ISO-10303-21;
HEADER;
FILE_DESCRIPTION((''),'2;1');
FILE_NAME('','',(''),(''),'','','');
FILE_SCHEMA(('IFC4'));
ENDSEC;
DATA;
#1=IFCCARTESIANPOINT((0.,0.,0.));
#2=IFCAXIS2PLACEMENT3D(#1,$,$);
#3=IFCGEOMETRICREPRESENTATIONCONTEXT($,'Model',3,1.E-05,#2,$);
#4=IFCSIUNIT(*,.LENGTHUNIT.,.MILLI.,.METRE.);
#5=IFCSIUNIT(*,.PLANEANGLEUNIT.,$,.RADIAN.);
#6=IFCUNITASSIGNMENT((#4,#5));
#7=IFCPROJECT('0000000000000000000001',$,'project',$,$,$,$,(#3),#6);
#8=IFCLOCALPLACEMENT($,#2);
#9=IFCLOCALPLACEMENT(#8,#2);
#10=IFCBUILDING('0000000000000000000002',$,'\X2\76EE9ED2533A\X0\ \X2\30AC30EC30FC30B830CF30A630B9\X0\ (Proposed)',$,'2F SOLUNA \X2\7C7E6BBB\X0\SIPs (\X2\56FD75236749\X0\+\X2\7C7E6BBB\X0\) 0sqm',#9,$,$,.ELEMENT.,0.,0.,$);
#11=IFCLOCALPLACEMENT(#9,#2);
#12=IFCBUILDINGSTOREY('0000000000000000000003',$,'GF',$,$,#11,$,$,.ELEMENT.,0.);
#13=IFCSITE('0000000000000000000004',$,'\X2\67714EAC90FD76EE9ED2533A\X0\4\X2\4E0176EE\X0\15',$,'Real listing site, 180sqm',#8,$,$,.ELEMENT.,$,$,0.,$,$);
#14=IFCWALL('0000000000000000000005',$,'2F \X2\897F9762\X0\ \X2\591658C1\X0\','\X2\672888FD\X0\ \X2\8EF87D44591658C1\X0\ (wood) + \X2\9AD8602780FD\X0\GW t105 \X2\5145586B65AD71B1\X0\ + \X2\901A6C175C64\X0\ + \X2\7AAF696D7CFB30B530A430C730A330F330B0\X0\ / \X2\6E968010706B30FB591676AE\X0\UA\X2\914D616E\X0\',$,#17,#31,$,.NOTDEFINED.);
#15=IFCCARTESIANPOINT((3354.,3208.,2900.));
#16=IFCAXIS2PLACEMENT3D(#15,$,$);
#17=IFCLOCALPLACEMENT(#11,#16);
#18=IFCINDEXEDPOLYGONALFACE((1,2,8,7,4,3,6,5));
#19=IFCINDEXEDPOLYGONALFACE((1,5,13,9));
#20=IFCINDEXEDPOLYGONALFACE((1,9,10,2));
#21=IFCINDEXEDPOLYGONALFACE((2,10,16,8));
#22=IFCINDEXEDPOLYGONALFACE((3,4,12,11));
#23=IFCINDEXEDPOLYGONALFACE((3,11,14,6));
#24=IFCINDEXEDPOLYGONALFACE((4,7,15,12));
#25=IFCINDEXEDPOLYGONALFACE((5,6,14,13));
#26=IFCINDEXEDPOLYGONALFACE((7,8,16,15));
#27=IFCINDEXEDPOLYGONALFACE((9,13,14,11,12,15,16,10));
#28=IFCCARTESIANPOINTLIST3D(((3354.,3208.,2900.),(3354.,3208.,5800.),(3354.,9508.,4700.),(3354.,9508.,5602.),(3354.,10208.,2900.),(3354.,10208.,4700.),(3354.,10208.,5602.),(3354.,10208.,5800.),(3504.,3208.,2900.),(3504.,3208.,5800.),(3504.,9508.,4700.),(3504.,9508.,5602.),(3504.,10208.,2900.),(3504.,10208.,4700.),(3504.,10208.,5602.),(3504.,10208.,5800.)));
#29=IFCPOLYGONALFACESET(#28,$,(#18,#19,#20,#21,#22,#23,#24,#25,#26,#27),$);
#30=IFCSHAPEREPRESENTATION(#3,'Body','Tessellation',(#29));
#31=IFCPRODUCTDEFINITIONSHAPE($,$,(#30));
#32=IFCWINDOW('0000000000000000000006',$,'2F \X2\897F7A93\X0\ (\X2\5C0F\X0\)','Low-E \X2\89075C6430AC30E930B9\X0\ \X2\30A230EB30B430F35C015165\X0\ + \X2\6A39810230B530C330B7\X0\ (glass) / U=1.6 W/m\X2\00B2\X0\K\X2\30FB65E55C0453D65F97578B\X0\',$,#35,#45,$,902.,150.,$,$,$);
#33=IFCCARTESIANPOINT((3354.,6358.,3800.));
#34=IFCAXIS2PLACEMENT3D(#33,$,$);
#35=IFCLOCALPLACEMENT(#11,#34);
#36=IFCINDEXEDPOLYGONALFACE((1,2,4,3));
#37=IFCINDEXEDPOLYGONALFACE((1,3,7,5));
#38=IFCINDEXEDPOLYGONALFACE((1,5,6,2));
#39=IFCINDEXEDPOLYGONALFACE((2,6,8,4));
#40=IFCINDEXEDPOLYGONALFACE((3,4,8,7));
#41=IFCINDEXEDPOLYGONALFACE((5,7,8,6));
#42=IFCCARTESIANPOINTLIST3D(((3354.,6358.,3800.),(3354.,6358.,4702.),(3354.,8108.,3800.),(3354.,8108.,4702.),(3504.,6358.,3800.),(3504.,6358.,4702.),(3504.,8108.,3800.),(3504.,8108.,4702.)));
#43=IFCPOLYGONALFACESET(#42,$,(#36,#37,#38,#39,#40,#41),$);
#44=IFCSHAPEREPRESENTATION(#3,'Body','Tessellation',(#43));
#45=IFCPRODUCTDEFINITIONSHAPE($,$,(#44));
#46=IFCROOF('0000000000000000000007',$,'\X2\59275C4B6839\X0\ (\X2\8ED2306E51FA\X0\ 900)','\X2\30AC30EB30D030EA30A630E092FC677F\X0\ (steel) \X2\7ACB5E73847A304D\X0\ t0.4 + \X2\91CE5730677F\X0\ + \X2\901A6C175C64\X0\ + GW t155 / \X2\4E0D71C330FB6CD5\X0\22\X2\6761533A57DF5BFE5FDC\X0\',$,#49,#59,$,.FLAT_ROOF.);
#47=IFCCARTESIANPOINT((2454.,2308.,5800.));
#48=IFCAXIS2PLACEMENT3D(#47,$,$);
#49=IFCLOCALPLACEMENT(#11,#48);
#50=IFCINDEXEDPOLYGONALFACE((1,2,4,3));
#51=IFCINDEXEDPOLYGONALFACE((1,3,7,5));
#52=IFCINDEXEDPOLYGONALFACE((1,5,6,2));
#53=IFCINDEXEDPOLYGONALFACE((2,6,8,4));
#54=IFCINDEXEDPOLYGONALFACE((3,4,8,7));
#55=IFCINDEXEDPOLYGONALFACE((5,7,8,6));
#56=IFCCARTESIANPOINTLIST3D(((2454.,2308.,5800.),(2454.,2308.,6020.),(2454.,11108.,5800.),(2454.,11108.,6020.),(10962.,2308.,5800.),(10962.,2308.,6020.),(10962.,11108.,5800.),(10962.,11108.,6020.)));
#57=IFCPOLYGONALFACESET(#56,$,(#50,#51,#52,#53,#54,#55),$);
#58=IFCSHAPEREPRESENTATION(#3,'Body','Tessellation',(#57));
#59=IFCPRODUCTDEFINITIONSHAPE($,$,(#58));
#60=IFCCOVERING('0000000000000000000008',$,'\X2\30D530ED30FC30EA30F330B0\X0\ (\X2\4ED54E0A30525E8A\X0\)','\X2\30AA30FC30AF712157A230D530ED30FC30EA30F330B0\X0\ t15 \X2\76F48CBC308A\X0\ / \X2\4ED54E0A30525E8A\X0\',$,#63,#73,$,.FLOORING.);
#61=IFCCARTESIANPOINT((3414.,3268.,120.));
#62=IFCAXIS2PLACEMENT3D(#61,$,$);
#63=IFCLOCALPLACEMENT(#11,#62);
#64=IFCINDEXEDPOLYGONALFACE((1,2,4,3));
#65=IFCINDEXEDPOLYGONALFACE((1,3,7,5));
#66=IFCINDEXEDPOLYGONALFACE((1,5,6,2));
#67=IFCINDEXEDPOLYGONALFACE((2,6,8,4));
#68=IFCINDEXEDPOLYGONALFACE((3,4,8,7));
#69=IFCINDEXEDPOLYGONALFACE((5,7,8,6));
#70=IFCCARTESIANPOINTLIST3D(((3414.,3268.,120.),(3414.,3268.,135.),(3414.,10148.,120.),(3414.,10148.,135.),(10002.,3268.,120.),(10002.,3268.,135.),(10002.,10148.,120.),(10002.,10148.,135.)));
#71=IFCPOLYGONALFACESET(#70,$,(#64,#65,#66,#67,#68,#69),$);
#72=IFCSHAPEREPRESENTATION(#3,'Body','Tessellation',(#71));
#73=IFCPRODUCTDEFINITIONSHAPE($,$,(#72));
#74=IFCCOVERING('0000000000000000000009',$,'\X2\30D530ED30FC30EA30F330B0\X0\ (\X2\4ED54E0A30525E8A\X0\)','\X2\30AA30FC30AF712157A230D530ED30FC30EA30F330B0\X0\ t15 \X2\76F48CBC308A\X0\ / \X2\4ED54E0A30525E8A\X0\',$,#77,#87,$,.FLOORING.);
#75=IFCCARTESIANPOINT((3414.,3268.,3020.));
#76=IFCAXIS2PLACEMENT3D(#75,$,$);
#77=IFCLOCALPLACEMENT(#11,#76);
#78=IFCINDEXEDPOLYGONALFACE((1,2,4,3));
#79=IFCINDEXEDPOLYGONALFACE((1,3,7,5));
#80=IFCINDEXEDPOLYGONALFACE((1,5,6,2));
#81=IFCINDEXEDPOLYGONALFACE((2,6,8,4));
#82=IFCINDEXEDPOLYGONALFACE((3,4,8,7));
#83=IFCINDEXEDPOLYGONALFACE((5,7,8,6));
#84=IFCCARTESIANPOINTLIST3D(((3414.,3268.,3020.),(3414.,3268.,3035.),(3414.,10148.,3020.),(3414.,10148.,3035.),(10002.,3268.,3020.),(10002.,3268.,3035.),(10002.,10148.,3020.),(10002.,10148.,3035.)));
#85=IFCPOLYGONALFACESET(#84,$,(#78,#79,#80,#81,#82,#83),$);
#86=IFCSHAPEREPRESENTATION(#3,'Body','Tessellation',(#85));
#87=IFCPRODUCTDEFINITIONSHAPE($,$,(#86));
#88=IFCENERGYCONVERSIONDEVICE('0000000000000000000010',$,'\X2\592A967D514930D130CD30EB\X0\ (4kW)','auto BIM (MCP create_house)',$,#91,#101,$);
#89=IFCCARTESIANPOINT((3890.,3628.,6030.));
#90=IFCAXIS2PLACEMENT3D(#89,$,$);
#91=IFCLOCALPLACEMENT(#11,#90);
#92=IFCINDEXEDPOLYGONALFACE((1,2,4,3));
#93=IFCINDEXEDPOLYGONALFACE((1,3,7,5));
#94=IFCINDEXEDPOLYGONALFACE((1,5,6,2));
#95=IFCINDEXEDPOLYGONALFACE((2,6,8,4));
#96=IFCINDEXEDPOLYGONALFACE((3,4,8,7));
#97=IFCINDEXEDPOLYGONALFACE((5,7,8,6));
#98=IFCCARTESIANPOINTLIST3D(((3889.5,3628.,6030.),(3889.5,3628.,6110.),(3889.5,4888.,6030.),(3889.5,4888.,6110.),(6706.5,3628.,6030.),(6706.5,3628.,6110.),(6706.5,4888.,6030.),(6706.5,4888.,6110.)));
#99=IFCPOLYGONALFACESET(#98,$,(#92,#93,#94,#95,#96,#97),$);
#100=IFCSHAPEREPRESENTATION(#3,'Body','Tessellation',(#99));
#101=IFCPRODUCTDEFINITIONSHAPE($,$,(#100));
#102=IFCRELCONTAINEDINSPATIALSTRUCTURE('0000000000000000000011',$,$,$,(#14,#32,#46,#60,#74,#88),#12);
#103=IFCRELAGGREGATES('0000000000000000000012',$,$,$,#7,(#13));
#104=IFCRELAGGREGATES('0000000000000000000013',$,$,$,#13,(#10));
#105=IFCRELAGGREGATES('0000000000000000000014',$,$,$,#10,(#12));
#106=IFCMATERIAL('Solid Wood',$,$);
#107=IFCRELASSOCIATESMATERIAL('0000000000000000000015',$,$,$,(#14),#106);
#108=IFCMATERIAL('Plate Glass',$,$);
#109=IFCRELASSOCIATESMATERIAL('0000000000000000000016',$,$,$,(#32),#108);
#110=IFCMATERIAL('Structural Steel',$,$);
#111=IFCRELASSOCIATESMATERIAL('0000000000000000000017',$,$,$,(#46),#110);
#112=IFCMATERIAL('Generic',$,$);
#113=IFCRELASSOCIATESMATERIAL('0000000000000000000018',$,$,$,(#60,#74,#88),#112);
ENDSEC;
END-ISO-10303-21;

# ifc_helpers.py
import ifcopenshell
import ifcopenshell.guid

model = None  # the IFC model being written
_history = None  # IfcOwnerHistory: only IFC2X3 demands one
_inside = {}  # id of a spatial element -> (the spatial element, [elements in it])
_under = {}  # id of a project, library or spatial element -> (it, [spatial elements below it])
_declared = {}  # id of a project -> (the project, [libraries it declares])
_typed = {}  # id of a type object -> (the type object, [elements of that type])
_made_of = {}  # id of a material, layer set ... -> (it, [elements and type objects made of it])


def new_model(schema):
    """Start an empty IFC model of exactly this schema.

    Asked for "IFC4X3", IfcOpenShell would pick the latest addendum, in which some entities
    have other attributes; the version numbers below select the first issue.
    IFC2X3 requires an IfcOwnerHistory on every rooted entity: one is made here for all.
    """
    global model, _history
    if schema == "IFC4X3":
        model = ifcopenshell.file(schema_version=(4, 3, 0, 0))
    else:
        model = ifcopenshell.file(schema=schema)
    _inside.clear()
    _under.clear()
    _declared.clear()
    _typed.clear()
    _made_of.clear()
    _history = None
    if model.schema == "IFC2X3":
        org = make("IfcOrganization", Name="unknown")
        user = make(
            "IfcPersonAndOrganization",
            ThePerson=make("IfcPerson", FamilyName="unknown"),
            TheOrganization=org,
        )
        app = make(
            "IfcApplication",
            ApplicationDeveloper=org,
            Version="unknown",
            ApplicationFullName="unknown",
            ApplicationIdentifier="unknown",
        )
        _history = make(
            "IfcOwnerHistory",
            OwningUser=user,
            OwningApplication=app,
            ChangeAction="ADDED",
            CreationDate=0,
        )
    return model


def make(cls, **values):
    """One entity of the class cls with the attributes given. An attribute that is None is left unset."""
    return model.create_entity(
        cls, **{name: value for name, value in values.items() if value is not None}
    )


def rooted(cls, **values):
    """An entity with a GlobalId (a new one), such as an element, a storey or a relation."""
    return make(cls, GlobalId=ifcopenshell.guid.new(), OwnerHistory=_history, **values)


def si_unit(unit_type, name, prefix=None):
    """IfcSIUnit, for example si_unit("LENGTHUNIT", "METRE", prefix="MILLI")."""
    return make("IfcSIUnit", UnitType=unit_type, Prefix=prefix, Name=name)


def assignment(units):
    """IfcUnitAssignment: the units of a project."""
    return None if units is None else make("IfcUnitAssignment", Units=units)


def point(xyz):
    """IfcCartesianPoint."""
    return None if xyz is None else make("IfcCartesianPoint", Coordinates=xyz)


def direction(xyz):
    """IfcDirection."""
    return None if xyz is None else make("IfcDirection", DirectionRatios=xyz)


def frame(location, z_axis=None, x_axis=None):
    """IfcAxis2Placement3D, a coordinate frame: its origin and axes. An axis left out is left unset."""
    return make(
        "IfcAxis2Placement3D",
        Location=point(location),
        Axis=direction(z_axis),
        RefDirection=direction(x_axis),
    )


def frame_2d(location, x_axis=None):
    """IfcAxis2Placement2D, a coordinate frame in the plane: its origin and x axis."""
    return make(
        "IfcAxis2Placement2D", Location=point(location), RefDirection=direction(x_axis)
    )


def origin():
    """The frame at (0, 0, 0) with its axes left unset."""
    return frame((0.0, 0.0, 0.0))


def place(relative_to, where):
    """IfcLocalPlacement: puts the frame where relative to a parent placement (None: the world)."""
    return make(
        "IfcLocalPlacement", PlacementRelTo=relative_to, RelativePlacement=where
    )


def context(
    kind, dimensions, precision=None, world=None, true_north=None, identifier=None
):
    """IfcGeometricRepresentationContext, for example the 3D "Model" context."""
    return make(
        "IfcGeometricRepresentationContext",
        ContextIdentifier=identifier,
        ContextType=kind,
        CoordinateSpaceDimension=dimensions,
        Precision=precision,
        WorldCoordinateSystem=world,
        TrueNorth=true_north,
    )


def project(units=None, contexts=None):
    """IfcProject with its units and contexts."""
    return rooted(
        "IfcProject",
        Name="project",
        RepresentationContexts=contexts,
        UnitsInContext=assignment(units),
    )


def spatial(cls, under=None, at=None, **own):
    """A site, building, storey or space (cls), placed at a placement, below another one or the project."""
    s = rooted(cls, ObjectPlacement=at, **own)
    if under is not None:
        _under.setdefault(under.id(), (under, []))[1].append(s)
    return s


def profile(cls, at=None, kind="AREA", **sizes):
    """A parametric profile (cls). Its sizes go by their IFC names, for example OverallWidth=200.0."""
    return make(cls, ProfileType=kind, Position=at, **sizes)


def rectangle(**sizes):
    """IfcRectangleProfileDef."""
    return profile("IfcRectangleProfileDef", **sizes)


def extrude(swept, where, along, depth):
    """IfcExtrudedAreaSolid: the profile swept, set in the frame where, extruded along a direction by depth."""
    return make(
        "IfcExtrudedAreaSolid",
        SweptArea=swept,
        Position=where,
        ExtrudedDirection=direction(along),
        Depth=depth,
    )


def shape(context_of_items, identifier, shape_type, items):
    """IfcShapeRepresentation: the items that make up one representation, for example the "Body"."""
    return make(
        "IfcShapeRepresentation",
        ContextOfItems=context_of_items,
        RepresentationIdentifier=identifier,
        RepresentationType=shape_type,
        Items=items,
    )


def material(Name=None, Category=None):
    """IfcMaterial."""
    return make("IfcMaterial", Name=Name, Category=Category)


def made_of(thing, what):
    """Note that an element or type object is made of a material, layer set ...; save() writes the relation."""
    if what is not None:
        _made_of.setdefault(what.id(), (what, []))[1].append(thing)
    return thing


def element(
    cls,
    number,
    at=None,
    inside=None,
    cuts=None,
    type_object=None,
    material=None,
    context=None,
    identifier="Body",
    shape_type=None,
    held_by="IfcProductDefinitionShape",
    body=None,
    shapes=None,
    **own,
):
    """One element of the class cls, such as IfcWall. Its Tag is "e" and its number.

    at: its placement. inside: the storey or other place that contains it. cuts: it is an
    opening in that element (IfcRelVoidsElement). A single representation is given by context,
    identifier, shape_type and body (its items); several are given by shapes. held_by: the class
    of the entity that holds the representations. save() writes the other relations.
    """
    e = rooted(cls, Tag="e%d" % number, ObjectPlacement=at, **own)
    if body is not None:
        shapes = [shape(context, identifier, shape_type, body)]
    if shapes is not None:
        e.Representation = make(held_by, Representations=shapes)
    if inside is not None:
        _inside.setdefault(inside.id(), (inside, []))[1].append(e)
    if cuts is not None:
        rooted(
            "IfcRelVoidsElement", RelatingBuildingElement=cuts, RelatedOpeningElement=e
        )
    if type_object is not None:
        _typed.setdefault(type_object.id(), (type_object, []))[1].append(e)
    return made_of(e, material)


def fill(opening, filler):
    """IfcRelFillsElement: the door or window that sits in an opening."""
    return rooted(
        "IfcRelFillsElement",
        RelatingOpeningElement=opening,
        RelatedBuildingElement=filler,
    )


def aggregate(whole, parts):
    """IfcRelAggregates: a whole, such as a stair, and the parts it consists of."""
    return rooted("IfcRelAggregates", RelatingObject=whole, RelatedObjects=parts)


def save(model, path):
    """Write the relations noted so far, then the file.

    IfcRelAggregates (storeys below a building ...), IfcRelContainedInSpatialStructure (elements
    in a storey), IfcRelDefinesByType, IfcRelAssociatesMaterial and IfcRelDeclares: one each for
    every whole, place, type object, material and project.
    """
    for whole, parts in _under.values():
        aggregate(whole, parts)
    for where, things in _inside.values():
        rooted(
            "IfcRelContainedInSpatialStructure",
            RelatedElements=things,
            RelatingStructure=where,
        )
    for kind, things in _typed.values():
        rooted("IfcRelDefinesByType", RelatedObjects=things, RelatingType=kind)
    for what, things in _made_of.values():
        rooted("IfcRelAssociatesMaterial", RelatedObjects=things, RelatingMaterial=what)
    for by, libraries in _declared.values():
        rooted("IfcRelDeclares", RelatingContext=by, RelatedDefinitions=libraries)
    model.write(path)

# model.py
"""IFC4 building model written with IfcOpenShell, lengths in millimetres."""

from ifc_helpers import new_model, si_unit, frame, frame_2d, origin, place, context, project, spatial, rectangle, extrude, material, element, fill, save


model = new_model("IFC4")

# Units and contexts
model_context = context("Model", 3, precision=1e-05, world=origin())
ifc_project = project(units=[si_unit("LENGTHUNIT", "METRE", prefix="MILLI"), si_unit("PLANEANGLEUNIT", "RADIAN")], contexts=[model_context])

# Site, building, storey
site_placement = place(None, origin())
site = spatial("IfcSite", under=ifc_project, at=site_placement, Name="東京都目黒区4丁目15", ObjectType="Real listing site, 180sqm", CompositionType="ELEMENT", RefElevation=0.0)
building_placement = place(site_placement, origin())
building = spatial("IfcBuilding", under=site, at=building_placement, Name="目黒区 ガレージハウス (Proposed)", ObjectType="2F SOLUNA 籾殻SIPs (国産杉+籾殻) 0sqm", CompositionType="ELEMENT", ElevationOfRefHeight=0.0, ElevationOfTerrain=0.0)
storey_placement = place(building_placement, origin())
storey = spatial("IfcBuildingStorey", under=building, at=storey_placement, Name="GF", CompositionType="ELEMENT", Elevation=0.0)

# Shared definitions
ifc_material_1 = material(Name="Solid Wood")

# Shared definitions
ifc_material_2 = material(Name="Plate Glass")

# Wall, opening, window
wall_1_placement = place(storey_placement, frame((3354.0, 3208.0, 2900.0)))
wall_1 = element("IfcWall", 1, at=wall_1_placement, inside=storey, material=ifc_material_1, Name="2F 西面 外壁", Description="木製 軸組外壁 (wood) + 高性能GW t105 充填断熱 + 通気層 + 窯業系サイディング / 準耐火・外皮UA配慮", PredefinedType="NOTDEFINED", context=model_context, shape_type="SweptSolid", body=[
    extrude(rectangle(XDim=150.0, YDim=7000.0, at=frame_2d((75.0, 3500.0))), frame((3354.0, 3208.0, 2900.0)), (0.0, 0.0, 1.0), 2900.0),
])
opening_1_placement = place(storey_placement, frame((3354.0, 6358.0, 3800.0)))
opening_1 = element("IfcOpeningElement", 2, at=opening_1_placement, cuts=wall_1, PredefinedType="NOTDEFINED", context=model_context, shape_type="SweptSolid", body=[
    extrude(rectangle(XDim=150.0, YDim=1750.0, at=frame_2d((75.0, 875.0))), frame((3354.0, 6358.0, 3800.0)), (0.0, 0.0, 1.0), 902.0),
])
window_1_placement = place(storey_placement, frame((3354.0, 6358.0, 3800.0)))
window_1 = element("IfcWindow", 3, at=window_1_placement, inside=storey, material=ifc_material_2, Name="2F 西窓 (小)", Description="Low-E 複層ガラス アルゴン封入 + 樹脂サッシ (glass) / U=1.6 W/m²K・日射取得型", OverallHeight=902.0, OverallWidth=150.0, context=model_context, shape_type="SweptSolid", body=[
    extrude(rectangle(XDim=150.0, YDim=1750.0, at=frame_2d((75.0, 875.0))), frame((3354.0, 6358.0, 3800.0)), (0.0, 0.0, 1.0), 902.0),
])
fill(opening_1, window_1)

# Roof
ifc_material_3 = material(Name="Structural Steel")
roof_placement = place(storey_placement, frame((2454.0, 2308.0, 5800.0)))
element("IfcRoof", 4, at=roof_placement, inside=storey, material=ifc_material_3, Name="大屋根 (軒の出 900)", Description="ガルバリウム鋼板 (steel) 立平葺き t0.4 + 野地板 + 通気層 + GW t155 / 不燃・法22条区域対応", PredefinedType="FLAT_ROOF", context=model_context, shape_type="SweptSolid", body=[
    extrude(rectangle(XDim=8508.0, YDim=8800.0, at=frame_2d((4254.0, 4400.0))), frame((2454.0, 2308.0, 5800.0)), (0.0, 0.0, 1.0), 220.0),
])

# Coverings
ifc_material_4 = material(Name="Generic")
covering_1_placement = place(storey_placement, frame((3414.0, 3268.0, 120.0)))
element("IfcCovering", 5, at=covering_1_placement, inside=storey, material=ifc_material_4, Name="フローリング (仕上げ床)", Description="オーク無垢フローリング t15 直貼り / 仕上げ床", PredefinedType="FLOORING", context=model_context, shape_type="SweptSolid", body=[
    extrude(rectangle(XDim=6588.0, YDim=6880.0, at=frame_2d((3294.0, 3440.0))), frame((3414.0, 3268.0, 120.0)), (0.0, 0.0, 1.0), 15.0),
])
covering_2_placement = place(storey_placement, frame((3414.0, 3268.0, 3020.0)))
element("IfcCovering", 6, at=covering_2_placement, inside=storey, material=ifc_material_4, Name="フローリング (仕上げ床)", Description="オーク無垢フローリング t15 直貼り / 仕上げ床", PredefinedType="FLOORING", context=model_context, shape_type="SweptSolid", body=[
    extrude(rectangle(XDim=6588.0, YDim=6880.0, at=frame_2d((3294.0, 3440.0))), frame((3414.0, 3268.0, 3020.0)), (0.0, 0.0, 1.0), 15.0),
])

# Energy conversion device
energy_conversion_device_placement = place(storey_placement, frame((3890.0, 3628.0, 6030.0)))
element("IfcEnergyConversionDevice", 7, at=energy_conversion_device_placement, inside=storey, material=ifc_material_4, Name="太陽光パネル (4kW)", Description="auto BIM (MCP create_house)", context=model_context, shape_type="SweptSolid", body=[
    extrude(rectangle(XDim=2817.0, YDim=1260.0, at=frame_2d((1408.0, 630.0))), frame((3890.0, 3628.0, 6030.0)), (0.0, 0.0, 1.0), 80.0),
])

save(model, "model.ifc")
